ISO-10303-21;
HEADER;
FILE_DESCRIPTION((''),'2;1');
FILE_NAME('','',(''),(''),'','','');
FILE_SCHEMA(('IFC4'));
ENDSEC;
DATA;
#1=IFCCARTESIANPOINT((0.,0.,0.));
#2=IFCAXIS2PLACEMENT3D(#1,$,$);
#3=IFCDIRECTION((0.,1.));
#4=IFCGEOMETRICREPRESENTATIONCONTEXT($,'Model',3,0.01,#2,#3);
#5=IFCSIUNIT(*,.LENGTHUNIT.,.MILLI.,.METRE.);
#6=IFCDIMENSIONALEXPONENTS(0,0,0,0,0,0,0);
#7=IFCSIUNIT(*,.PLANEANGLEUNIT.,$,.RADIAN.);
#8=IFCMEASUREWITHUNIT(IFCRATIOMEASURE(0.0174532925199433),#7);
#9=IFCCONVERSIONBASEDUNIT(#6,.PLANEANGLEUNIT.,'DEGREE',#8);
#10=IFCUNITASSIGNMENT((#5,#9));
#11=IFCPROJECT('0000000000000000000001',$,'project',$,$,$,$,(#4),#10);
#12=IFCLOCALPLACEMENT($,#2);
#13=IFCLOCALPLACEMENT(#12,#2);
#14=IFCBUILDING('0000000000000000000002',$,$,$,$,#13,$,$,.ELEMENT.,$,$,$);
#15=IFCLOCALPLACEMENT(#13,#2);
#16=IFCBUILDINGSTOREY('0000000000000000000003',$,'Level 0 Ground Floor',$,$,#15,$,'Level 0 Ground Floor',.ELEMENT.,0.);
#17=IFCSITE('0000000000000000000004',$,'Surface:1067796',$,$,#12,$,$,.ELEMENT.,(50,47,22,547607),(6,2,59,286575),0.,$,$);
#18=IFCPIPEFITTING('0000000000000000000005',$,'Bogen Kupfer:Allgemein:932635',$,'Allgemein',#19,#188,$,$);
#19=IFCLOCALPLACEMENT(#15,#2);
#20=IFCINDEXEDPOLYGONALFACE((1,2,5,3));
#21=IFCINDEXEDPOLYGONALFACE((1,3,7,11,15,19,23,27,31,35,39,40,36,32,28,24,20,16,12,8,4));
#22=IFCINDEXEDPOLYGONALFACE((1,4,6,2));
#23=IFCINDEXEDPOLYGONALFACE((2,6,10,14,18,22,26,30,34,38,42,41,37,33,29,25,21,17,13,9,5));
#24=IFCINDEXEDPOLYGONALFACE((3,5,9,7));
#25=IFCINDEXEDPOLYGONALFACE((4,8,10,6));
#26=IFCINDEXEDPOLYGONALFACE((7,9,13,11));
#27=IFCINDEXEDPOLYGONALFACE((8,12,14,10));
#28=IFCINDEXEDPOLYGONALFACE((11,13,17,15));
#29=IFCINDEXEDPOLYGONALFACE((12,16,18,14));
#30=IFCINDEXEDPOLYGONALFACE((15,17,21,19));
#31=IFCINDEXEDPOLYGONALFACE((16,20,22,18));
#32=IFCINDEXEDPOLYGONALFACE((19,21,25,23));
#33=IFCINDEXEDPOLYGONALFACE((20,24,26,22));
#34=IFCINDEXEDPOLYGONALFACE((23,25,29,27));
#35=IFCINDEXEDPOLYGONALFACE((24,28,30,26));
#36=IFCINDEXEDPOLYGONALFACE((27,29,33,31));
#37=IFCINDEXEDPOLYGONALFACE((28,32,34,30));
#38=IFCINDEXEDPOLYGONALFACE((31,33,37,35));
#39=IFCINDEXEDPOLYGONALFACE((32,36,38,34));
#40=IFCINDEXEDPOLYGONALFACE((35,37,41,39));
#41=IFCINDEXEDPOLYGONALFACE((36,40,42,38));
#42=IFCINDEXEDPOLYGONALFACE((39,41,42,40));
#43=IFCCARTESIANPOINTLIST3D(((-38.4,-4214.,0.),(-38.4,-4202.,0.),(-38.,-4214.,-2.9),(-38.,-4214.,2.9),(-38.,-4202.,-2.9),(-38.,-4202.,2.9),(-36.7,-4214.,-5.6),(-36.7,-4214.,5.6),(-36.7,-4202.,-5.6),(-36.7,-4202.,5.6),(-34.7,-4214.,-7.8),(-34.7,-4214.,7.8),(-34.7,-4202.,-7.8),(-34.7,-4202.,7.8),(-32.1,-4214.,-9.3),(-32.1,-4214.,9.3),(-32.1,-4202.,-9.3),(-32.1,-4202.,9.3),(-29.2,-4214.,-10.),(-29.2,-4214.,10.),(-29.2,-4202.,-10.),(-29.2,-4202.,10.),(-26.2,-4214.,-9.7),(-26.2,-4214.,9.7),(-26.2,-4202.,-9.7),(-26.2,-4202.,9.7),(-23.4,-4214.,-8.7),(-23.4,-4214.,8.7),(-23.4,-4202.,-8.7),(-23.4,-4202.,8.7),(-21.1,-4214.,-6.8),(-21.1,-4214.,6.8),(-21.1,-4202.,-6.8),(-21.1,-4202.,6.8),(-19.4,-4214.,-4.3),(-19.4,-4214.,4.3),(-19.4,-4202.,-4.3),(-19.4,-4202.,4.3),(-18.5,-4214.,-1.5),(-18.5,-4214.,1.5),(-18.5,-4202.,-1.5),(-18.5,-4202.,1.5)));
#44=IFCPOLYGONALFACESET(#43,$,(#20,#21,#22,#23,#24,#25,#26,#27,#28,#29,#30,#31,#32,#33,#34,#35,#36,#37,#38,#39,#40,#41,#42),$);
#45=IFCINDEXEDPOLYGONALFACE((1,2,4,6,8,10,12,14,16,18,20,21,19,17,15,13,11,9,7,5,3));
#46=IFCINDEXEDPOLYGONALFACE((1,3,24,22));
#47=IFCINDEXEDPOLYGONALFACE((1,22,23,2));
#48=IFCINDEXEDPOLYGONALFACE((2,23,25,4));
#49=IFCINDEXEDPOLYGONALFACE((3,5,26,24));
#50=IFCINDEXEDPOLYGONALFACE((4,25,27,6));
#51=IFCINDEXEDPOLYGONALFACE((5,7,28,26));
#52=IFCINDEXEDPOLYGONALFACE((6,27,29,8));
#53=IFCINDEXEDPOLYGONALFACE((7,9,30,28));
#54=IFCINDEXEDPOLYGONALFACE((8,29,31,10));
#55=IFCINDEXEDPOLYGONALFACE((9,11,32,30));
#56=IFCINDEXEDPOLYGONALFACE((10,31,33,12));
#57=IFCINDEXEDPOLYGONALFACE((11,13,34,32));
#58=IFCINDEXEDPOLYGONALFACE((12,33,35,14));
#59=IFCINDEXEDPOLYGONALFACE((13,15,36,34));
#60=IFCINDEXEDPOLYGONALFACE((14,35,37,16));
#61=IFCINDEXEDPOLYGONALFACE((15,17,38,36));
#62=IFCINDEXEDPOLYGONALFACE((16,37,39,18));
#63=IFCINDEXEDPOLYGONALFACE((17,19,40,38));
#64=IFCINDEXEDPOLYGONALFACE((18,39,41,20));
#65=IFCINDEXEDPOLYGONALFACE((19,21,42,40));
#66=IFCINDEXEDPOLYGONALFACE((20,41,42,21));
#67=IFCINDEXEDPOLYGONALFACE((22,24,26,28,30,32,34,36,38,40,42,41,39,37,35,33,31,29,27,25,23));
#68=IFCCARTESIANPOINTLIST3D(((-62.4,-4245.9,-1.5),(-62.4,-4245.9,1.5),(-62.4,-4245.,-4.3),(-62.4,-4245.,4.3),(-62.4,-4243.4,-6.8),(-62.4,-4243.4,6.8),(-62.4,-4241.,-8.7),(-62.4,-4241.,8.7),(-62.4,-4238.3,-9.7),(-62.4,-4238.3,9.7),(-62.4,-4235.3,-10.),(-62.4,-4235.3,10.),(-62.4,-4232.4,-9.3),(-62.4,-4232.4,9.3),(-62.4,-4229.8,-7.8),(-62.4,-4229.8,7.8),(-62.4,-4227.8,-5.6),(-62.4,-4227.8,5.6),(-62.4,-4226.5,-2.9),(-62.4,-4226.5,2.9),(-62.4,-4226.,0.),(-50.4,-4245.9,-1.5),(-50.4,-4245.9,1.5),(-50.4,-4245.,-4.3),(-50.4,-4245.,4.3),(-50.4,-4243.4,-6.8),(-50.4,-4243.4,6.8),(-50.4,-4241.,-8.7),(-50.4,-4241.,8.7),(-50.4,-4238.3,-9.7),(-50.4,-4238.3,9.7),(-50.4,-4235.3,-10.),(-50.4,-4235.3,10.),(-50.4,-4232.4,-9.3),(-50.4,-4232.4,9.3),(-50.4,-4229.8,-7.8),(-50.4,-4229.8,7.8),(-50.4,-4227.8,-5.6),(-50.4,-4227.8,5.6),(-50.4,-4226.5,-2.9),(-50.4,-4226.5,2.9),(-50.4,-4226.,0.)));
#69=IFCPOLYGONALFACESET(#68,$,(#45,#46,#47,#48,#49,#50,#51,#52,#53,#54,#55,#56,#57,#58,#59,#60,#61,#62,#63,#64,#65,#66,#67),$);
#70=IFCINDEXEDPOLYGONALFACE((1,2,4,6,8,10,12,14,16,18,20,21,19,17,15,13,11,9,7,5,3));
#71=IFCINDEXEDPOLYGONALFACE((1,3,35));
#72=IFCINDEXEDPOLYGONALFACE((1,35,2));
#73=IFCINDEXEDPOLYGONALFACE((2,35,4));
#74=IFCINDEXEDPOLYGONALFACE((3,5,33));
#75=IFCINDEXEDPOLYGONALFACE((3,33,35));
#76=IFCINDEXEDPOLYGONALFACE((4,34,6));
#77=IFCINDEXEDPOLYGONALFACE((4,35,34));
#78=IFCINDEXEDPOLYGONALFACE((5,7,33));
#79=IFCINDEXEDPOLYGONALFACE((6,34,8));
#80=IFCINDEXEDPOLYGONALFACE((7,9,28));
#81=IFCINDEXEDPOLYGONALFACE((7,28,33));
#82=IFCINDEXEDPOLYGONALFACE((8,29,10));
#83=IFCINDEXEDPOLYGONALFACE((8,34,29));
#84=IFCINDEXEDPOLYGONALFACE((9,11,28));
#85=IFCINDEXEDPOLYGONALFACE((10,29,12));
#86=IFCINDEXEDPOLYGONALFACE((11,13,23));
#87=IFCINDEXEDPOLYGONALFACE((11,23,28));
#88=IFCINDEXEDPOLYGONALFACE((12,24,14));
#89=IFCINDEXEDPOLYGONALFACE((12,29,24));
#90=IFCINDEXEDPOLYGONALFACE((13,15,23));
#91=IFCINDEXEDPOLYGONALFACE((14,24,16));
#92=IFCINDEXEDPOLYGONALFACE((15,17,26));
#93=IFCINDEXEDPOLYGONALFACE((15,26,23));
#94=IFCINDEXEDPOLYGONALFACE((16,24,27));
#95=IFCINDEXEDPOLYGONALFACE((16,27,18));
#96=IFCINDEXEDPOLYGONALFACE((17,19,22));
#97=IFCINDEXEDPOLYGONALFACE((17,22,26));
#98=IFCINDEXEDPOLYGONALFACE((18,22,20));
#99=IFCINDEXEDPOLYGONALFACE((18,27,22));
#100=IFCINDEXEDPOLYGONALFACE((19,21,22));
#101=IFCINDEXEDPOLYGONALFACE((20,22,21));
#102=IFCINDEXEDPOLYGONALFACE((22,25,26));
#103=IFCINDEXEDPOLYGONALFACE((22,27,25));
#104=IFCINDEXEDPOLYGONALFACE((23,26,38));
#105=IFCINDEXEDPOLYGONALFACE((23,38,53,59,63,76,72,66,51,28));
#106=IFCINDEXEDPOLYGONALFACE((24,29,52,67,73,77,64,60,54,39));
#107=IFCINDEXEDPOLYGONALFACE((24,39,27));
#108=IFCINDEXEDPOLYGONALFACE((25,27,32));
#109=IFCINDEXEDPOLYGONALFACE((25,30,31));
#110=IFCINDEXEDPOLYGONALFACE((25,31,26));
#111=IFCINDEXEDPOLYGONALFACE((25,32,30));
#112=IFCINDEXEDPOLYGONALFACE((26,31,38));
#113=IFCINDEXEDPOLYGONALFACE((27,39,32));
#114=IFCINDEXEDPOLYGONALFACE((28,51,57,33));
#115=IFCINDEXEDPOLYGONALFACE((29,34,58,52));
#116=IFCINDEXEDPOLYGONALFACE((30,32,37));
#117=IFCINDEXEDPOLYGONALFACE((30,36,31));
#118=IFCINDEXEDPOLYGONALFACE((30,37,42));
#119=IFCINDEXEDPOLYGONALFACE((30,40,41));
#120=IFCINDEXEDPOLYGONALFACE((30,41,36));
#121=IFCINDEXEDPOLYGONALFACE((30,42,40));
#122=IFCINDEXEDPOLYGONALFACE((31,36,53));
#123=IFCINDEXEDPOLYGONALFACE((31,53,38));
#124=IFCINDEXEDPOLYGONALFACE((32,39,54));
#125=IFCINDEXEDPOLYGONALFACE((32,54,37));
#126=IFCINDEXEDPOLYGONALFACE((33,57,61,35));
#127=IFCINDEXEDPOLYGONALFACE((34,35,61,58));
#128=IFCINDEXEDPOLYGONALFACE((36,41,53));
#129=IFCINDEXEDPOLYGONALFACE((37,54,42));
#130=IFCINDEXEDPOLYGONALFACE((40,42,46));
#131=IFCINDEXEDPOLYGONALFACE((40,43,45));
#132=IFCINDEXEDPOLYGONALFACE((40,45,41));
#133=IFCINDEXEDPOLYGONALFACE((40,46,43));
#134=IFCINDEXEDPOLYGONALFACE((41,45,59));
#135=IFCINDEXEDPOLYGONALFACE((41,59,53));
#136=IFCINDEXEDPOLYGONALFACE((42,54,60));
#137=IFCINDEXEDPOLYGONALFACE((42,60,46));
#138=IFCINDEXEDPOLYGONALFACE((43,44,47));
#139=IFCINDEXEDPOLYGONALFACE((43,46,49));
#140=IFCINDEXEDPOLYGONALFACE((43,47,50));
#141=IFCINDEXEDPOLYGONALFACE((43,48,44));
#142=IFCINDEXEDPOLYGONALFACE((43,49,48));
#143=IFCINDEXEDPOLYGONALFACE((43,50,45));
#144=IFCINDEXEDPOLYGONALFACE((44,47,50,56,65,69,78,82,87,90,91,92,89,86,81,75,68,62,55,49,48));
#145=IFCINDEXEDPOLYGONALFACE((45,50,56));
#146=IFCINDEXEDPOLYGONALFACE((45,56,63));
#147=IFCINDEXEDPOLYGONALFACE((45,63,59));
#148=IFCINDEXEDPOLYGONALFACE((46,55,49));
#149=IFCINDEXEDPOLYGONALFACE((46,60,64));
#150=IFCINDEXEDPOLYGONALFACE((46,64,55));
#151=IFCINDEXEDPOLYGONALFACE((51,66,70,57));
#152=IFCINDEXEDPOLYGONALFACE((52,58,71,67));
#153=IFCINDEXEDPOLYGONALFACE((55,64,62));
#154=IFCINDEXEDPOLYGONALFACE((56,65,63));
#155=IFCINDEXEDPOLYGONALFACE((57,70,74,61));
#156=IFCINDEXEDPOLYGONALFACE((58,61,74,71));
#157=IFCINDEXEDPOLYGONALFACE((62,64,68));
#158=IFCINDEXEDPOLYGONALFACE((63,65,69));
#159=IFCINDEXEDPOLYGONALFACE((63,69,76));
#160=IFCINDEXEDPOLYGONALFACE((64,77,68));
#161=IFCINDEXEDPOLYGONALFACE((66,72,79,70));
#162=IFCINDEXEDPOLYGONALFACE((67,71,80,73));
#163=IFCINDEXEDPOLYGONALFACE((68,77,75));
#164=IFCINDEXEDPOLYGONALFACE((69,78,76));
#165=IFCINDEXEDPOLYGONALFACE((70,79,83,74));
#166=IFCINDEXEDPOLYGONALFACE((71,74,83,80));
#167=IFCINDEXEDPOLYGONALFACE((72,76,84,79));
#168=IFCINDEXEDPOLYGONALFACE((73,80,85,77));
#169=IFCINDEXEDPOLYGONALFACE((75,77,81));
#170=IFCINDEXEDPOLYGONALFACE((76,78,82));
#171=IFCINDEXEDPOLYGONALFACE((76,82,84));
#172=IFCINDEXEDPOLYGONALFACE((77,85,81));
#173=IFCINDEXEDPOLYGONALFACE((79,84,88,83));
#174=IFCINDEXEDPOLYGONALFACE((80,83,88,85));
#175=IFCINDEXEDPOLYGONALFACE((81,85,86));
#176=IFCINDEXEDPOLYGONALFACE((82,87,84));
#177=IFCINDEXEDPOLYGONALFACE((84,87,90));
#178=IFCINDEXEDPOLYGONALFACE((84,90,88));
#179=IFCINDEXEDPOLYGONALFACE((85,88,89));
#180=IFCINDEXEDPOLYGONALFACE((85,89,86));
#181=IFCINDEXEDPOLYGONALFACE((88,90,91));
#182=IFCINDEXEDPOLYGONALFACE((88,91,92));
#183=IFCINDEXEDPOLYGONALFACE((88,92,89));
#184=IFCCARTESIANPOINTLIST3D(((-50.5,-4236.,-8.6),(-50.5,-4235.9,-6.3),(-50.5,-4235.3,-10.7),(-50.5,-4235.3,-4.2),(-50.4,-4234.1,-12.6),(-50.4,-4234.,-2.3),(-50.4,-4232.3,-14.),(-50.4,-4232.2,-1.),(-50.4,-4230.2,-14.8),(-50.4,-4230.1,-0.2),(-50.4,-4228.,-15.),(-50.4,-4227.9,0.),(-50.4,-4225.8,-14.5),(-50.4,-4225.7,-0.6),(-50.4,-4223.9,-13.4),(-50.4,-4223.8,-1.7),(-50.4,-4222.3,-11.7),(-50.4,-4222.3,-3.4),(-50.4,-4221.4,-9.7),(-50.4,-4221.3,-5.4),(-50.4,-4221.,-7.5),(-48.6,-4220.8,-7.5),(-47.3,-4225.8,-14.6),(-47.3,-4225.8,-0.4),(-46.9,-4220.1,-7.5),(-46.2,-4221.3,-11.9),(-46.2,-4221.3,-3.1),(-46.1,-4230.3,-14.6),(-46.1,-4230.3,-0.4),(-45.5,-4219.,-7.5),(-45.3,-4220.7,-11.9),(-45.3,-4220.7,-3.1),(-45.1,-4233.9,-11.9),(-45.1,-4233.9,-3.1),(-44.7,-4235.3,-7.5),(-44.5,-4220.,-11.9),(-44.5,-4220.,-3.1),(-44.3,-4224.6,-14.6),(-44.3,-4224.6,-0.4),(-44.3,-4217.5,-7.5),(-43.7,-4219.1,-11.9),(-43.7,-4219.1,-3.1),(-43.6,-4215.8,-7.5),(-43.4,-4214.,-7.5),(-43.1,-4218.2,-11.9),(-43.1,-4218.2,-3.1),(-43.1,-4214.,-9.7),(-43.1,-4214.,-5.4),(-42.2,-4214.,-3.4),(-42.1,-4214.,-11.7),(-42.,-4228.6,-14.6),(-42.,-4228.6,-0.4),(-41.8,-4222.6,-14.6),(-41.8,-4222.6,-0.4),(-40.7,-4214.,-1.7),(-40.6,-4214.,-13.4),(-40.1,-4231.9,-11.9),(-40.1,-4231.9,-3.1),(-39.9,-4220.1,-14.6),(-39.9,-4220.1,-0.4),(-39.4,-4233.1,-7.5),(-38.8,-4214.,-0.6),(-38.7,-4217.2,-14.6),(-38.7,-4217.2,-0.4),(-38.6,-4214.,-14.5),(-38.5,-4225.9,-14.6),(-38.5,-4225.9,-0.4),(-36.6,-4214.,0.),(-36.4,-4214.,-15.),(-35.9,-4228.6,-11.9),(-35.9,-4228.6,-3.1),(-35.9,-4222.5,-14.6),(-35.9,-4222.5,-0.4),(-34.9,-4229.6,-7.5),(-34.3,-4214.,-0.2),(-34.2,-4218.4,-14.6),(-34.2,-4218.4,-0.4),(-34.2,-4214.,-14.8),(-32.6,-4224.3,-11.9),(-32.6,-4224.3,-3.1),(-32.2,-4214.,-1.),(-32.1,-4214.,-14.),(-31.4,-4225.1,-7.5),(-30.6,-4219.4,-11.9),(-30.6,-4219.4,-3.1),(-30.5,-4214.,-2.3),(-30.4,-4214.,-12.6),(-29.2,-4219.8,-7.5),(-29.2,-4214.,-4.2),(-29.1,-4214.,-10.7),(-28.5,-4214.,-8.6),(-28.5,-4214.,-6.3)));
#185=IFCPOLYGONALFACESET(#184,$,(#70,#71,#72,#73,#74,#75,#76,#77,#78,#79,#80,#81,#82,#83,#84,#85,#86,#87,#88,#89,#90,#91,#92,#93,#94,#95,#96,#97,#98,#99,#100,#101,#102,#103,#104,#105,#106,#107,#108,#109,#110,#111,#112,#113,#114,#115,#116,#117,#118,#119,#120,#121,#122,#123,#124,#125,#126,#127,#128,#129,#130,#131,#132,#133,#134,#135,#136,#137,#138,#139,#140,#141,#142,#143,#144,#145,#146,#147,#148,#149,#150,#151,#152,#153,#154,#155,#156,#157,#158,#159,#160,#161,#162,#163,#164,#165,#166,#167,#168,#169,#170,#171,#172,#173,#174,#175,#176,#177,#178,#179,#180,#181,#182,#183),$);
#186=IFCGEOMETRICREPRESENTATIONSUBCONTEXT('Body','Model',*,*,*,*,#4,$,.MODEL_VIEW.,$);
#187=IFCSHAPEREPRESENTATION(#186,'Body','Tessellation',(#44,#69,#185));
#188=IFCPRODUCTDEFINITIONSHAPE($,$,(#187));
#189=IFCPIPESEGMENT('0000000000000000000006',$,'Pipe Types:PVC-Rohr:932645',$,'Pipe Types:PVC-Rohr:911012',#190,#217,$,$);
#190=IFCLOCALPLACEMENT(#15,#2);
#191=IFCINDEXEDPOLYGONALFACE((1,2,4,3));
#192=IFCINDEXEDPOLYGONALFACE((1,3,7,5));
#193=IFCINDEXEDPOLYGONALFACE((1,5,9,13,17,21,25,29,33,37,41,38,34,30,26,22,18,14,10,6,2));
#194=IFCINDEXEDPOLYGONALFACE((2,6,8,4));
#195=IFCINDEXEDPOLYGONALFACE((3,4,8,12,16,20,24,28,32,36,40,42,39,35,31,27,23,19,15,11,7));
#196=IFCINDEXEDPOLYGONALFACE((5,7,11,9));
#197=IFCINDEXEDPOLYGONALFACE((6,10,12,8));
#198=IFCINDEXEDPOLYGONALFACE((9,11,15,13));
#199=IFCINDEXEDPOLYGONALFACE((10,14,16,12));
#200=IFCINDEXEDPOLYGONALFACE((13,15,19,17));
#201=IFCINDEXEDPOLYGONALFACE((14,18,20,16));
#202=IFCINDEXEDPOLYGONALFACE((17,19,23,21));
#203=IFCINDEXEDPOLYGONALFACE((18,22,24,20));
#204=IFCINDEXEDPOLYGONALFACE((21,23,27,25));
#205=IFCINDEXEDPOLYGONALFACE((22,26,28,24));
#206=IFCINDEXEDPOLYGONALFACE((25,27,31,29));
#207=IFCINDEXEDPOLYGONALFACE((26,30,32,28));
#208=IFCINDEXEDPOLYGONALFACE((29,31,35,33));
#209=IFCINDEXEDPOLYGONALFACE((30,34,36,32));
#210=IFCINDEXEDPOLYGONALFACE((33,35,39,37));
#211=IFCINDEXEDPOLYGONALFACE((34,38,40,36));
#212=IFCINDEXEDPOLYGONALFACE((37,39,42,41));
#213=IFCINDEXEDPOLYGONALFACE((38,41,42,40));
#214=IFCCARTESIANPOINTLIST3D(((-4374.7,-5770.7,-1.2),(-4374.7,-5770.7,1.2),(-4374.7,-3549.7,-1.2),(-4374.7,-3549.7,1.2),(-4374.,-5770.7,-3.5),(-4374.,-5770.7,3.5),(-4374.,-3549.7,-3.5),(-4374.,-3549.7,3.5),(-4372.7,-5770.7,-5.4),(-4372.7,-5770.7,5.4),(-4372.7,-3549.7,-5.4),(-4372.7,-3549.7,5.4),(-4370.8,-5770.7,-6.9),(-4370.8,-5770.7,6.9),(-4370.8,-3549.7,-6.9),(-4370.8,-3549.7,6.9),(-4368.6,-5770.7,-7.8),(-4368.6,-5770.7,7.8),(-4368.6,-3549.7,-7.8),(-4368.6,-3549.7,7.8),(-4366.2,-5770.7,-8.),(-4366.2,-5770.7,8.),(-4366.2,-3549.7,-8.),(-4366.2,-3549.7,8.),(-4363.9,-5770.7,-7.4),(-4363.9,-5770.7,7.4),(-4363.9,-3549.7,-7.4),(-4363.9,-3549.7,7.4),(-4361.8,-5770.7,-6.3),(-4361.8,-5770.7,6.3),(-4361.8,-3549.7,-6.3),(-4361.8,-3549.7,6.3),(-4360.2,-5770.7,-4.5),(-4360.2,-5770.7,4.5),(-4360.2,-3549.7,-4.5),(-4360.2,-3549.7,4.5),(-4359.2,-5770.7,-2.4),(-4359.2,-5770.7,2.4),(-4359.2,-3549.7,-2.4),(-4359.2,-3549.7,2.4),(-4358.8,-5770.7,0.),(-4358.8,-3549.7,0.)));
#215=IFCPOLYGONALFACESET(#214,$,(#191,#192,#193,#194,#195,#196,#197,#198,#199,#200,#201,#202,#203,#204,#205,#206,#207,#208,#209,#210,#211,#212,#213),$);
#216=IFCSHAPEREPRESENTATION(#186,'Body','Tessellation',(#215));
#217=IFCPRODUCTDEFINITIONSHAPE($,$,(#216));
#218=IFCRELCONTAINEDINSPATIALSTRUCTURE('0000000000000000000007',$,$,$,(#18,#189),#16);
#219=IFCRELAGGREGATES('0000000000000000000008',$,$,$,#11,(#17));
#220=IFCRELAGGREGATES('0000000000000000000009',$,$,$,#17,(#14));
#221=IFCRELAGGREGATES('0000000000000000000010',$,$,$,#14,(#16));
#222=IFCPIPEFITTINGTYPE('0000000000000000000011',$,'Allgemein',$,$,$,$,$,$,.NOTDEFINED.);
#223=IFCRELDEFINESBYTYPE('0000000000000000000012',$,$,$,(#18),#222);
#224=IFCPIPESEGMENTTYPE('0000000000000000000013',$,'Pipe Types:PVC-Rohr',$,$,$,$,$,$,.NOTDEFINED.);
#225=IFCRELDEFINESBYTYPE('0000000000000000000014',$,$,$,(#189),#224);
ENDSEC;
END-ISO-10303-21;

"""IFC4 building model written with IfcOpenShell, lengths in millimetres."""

from ifc_helpers import new_model, entity, si_unit, converted_unit, direction, frame, frame_2d, origin, place, context, subcontext, project, spatial, circle, extrude, source, transform, mapped, type_object, type_shapes, element, save


model = new_model("IFC4")

# Units and contexts
model_context = context("Model", 3, precision=0.01, world=origin(), true_north=direction((0.0, 1.0)))
body_context = subcontext(model_context, "Body", "Model", "MODEL_VIEW")
ifc_project = project(units=[si_unit("LENGTHUNIT", "METRE", prefix="MILLI"), converted_unit("PLANEANGLEUNIT", "DEGREE", entity("IfcRatioMeasure", 0.0174532925199433), si_unit("PLANEANGLEUNIT", "RADIAN"), dimensions=[0, 0, 0, 0, 0, 0, 0])], contexts=[model_context])

# Site, building, storey
site_placement = place(None, origin())
site = spatial("IfcSite", under=ifc_project, at=site_placement, Name="Surface:1067796", CompositionType="ELEMENT", RefLatitude=(50, 47, 22, 547607), RefLongitude=(6, 2, 59, 286575), RefElevation=0.0)
building_placement = place(site_placement, origin())
building = spatial("IfcBuilding", under=site, at=building_placement, CompositionType="ELEMENT")
storey_placement = place(building_placement, origin())
storey = spatial("IfcBuildingStorey", under=building, at=storey_placement, Name="Level 0 Ground Floor", LongName="Level 0 Ground Floor", CompositionType="ELEMENT", Elevation=0.0)

# Pipe fitting
pipe_fitting_type_1 = type_object("IfcPipeFittingType", Name="Allgemein", PredefinedType="NOTDEFINED")
ifc_direction = entity("IfcDirection", [0.0, 0.0, -1.0])
trimmed_curve = entity("IfcTrimmedCurve", entity("IfcCircle", entity("IfcAxis2Placement2D", entity("IfcCartesianPoint", [-14.5, 0.0]), entity("IfcDirection", [0.0, 1.0])), 14.5), [entity("IfcParameterValue", 270.0)], [entity("IfcParameterValue", 0.0)], True, "PARAMETER")
shared_shape_1 = source(origin(), body_context, "Body", "SolidModel", [
    extrude(circle(Radius=10.0, at=frame_2d((0.0, 0.0), x_axis=(1.0, 0.0))), frame((0.0, 22.0, 0.0), z_axis=(0.0, 1.0, 0.0), x_axis=(-1.0, 0.0, 0.0)), (0.0, 0.0, 1.0), 12.0),
    extrude(circle(Radius=10.0, at=frame_2d((0.0, 0.0), x_axis=(1.0, 0.0))), frame((-34.0, 0.0, 0.0), z_axis=(1.0, 0.0, 0.0), x_axis=(0.0, 1.0, 0.0)), (0.0, 0.0, 1.0), 12.0),
    entity("IfcSurfaceCurveSweptAreaSolid", entity("IfcCircleProfileDef", "AREA", None, entity("IfcAxis2Placement2D", entity("IfcCartesianPoint", [0.0, 7.5]), entity("IfcDirection", [1.0, 0.0])), 7.5), entity("IfcAxis2Placement3D", entity("IfcCartesianPoint", [-7.5, 22.0, 0.0]), ifc_direction, entity("IfcDirection", [1.0, 0.0, 0.0])), trimmed_curve, 0.0, 90.0, entity("IfcSurfaceOfLinearExtrusion", entity("IfcArbitraryOpenProfileDef", "CURVE", None, trimmed_curve), entity("IfcAxis2Placement3D", entity("IfcCartesianPoint", [0.0, 0.0, -304.8])), ifc_direction, 1.0)),
])
type_shapes(pipe_fitting_type_1, [shared_shape_1])
pipe_fitting_1_placement = place(storey_placement, frame((-28.4, -4236.0, 0.0)))
element("IfcPipeFitting", 1, at=pipe_fitting_1_placement, inside=storey, type_object=pipe_fitting_type_1, Name="Bogen Kupfer:Allgemein:932635", ObjectType="Allgemein", context=body_context, shape_type="MappedRepresentation", body=[
    mapped(shared_shape_1, transform((0.0, 0.0, 0.0), scale=1.0)),
])

# Pipe segment
pipe_segment_type_1 = type_object("IfcPipeSegmentType", Name="Pipe Types:PVC-Rohr", PredefinedType="NOTDEFINED")
pipe_segment_1_placement = place(storey_placement, frame((-4376.4, -5770.7, -9.6)))
element("IfcPipeSegment", 2, at=pipe_segment_1_placement, inside=storey, type_object=pipe_segment_type_1, Name="Pipe Types:PVC-Rohr:932645", ObjectType="Pipe Types:PVC-Rohr:911012", context=body_context, shape_type="SweptSolid", body=[
    extrude(circle(Radius=8.0, at=frame_2d((0.0, 0.0), x_axis=(1.0, 0.0))), frame((9.6, 0.0, 9.6), z_axis=(0.0, 1.0, 0.0), x_axis=(1.0, 0.0, 0.0)), (0.0, 0.0, 1.0), 2221.0),
])

save(model, "model.ifc")
